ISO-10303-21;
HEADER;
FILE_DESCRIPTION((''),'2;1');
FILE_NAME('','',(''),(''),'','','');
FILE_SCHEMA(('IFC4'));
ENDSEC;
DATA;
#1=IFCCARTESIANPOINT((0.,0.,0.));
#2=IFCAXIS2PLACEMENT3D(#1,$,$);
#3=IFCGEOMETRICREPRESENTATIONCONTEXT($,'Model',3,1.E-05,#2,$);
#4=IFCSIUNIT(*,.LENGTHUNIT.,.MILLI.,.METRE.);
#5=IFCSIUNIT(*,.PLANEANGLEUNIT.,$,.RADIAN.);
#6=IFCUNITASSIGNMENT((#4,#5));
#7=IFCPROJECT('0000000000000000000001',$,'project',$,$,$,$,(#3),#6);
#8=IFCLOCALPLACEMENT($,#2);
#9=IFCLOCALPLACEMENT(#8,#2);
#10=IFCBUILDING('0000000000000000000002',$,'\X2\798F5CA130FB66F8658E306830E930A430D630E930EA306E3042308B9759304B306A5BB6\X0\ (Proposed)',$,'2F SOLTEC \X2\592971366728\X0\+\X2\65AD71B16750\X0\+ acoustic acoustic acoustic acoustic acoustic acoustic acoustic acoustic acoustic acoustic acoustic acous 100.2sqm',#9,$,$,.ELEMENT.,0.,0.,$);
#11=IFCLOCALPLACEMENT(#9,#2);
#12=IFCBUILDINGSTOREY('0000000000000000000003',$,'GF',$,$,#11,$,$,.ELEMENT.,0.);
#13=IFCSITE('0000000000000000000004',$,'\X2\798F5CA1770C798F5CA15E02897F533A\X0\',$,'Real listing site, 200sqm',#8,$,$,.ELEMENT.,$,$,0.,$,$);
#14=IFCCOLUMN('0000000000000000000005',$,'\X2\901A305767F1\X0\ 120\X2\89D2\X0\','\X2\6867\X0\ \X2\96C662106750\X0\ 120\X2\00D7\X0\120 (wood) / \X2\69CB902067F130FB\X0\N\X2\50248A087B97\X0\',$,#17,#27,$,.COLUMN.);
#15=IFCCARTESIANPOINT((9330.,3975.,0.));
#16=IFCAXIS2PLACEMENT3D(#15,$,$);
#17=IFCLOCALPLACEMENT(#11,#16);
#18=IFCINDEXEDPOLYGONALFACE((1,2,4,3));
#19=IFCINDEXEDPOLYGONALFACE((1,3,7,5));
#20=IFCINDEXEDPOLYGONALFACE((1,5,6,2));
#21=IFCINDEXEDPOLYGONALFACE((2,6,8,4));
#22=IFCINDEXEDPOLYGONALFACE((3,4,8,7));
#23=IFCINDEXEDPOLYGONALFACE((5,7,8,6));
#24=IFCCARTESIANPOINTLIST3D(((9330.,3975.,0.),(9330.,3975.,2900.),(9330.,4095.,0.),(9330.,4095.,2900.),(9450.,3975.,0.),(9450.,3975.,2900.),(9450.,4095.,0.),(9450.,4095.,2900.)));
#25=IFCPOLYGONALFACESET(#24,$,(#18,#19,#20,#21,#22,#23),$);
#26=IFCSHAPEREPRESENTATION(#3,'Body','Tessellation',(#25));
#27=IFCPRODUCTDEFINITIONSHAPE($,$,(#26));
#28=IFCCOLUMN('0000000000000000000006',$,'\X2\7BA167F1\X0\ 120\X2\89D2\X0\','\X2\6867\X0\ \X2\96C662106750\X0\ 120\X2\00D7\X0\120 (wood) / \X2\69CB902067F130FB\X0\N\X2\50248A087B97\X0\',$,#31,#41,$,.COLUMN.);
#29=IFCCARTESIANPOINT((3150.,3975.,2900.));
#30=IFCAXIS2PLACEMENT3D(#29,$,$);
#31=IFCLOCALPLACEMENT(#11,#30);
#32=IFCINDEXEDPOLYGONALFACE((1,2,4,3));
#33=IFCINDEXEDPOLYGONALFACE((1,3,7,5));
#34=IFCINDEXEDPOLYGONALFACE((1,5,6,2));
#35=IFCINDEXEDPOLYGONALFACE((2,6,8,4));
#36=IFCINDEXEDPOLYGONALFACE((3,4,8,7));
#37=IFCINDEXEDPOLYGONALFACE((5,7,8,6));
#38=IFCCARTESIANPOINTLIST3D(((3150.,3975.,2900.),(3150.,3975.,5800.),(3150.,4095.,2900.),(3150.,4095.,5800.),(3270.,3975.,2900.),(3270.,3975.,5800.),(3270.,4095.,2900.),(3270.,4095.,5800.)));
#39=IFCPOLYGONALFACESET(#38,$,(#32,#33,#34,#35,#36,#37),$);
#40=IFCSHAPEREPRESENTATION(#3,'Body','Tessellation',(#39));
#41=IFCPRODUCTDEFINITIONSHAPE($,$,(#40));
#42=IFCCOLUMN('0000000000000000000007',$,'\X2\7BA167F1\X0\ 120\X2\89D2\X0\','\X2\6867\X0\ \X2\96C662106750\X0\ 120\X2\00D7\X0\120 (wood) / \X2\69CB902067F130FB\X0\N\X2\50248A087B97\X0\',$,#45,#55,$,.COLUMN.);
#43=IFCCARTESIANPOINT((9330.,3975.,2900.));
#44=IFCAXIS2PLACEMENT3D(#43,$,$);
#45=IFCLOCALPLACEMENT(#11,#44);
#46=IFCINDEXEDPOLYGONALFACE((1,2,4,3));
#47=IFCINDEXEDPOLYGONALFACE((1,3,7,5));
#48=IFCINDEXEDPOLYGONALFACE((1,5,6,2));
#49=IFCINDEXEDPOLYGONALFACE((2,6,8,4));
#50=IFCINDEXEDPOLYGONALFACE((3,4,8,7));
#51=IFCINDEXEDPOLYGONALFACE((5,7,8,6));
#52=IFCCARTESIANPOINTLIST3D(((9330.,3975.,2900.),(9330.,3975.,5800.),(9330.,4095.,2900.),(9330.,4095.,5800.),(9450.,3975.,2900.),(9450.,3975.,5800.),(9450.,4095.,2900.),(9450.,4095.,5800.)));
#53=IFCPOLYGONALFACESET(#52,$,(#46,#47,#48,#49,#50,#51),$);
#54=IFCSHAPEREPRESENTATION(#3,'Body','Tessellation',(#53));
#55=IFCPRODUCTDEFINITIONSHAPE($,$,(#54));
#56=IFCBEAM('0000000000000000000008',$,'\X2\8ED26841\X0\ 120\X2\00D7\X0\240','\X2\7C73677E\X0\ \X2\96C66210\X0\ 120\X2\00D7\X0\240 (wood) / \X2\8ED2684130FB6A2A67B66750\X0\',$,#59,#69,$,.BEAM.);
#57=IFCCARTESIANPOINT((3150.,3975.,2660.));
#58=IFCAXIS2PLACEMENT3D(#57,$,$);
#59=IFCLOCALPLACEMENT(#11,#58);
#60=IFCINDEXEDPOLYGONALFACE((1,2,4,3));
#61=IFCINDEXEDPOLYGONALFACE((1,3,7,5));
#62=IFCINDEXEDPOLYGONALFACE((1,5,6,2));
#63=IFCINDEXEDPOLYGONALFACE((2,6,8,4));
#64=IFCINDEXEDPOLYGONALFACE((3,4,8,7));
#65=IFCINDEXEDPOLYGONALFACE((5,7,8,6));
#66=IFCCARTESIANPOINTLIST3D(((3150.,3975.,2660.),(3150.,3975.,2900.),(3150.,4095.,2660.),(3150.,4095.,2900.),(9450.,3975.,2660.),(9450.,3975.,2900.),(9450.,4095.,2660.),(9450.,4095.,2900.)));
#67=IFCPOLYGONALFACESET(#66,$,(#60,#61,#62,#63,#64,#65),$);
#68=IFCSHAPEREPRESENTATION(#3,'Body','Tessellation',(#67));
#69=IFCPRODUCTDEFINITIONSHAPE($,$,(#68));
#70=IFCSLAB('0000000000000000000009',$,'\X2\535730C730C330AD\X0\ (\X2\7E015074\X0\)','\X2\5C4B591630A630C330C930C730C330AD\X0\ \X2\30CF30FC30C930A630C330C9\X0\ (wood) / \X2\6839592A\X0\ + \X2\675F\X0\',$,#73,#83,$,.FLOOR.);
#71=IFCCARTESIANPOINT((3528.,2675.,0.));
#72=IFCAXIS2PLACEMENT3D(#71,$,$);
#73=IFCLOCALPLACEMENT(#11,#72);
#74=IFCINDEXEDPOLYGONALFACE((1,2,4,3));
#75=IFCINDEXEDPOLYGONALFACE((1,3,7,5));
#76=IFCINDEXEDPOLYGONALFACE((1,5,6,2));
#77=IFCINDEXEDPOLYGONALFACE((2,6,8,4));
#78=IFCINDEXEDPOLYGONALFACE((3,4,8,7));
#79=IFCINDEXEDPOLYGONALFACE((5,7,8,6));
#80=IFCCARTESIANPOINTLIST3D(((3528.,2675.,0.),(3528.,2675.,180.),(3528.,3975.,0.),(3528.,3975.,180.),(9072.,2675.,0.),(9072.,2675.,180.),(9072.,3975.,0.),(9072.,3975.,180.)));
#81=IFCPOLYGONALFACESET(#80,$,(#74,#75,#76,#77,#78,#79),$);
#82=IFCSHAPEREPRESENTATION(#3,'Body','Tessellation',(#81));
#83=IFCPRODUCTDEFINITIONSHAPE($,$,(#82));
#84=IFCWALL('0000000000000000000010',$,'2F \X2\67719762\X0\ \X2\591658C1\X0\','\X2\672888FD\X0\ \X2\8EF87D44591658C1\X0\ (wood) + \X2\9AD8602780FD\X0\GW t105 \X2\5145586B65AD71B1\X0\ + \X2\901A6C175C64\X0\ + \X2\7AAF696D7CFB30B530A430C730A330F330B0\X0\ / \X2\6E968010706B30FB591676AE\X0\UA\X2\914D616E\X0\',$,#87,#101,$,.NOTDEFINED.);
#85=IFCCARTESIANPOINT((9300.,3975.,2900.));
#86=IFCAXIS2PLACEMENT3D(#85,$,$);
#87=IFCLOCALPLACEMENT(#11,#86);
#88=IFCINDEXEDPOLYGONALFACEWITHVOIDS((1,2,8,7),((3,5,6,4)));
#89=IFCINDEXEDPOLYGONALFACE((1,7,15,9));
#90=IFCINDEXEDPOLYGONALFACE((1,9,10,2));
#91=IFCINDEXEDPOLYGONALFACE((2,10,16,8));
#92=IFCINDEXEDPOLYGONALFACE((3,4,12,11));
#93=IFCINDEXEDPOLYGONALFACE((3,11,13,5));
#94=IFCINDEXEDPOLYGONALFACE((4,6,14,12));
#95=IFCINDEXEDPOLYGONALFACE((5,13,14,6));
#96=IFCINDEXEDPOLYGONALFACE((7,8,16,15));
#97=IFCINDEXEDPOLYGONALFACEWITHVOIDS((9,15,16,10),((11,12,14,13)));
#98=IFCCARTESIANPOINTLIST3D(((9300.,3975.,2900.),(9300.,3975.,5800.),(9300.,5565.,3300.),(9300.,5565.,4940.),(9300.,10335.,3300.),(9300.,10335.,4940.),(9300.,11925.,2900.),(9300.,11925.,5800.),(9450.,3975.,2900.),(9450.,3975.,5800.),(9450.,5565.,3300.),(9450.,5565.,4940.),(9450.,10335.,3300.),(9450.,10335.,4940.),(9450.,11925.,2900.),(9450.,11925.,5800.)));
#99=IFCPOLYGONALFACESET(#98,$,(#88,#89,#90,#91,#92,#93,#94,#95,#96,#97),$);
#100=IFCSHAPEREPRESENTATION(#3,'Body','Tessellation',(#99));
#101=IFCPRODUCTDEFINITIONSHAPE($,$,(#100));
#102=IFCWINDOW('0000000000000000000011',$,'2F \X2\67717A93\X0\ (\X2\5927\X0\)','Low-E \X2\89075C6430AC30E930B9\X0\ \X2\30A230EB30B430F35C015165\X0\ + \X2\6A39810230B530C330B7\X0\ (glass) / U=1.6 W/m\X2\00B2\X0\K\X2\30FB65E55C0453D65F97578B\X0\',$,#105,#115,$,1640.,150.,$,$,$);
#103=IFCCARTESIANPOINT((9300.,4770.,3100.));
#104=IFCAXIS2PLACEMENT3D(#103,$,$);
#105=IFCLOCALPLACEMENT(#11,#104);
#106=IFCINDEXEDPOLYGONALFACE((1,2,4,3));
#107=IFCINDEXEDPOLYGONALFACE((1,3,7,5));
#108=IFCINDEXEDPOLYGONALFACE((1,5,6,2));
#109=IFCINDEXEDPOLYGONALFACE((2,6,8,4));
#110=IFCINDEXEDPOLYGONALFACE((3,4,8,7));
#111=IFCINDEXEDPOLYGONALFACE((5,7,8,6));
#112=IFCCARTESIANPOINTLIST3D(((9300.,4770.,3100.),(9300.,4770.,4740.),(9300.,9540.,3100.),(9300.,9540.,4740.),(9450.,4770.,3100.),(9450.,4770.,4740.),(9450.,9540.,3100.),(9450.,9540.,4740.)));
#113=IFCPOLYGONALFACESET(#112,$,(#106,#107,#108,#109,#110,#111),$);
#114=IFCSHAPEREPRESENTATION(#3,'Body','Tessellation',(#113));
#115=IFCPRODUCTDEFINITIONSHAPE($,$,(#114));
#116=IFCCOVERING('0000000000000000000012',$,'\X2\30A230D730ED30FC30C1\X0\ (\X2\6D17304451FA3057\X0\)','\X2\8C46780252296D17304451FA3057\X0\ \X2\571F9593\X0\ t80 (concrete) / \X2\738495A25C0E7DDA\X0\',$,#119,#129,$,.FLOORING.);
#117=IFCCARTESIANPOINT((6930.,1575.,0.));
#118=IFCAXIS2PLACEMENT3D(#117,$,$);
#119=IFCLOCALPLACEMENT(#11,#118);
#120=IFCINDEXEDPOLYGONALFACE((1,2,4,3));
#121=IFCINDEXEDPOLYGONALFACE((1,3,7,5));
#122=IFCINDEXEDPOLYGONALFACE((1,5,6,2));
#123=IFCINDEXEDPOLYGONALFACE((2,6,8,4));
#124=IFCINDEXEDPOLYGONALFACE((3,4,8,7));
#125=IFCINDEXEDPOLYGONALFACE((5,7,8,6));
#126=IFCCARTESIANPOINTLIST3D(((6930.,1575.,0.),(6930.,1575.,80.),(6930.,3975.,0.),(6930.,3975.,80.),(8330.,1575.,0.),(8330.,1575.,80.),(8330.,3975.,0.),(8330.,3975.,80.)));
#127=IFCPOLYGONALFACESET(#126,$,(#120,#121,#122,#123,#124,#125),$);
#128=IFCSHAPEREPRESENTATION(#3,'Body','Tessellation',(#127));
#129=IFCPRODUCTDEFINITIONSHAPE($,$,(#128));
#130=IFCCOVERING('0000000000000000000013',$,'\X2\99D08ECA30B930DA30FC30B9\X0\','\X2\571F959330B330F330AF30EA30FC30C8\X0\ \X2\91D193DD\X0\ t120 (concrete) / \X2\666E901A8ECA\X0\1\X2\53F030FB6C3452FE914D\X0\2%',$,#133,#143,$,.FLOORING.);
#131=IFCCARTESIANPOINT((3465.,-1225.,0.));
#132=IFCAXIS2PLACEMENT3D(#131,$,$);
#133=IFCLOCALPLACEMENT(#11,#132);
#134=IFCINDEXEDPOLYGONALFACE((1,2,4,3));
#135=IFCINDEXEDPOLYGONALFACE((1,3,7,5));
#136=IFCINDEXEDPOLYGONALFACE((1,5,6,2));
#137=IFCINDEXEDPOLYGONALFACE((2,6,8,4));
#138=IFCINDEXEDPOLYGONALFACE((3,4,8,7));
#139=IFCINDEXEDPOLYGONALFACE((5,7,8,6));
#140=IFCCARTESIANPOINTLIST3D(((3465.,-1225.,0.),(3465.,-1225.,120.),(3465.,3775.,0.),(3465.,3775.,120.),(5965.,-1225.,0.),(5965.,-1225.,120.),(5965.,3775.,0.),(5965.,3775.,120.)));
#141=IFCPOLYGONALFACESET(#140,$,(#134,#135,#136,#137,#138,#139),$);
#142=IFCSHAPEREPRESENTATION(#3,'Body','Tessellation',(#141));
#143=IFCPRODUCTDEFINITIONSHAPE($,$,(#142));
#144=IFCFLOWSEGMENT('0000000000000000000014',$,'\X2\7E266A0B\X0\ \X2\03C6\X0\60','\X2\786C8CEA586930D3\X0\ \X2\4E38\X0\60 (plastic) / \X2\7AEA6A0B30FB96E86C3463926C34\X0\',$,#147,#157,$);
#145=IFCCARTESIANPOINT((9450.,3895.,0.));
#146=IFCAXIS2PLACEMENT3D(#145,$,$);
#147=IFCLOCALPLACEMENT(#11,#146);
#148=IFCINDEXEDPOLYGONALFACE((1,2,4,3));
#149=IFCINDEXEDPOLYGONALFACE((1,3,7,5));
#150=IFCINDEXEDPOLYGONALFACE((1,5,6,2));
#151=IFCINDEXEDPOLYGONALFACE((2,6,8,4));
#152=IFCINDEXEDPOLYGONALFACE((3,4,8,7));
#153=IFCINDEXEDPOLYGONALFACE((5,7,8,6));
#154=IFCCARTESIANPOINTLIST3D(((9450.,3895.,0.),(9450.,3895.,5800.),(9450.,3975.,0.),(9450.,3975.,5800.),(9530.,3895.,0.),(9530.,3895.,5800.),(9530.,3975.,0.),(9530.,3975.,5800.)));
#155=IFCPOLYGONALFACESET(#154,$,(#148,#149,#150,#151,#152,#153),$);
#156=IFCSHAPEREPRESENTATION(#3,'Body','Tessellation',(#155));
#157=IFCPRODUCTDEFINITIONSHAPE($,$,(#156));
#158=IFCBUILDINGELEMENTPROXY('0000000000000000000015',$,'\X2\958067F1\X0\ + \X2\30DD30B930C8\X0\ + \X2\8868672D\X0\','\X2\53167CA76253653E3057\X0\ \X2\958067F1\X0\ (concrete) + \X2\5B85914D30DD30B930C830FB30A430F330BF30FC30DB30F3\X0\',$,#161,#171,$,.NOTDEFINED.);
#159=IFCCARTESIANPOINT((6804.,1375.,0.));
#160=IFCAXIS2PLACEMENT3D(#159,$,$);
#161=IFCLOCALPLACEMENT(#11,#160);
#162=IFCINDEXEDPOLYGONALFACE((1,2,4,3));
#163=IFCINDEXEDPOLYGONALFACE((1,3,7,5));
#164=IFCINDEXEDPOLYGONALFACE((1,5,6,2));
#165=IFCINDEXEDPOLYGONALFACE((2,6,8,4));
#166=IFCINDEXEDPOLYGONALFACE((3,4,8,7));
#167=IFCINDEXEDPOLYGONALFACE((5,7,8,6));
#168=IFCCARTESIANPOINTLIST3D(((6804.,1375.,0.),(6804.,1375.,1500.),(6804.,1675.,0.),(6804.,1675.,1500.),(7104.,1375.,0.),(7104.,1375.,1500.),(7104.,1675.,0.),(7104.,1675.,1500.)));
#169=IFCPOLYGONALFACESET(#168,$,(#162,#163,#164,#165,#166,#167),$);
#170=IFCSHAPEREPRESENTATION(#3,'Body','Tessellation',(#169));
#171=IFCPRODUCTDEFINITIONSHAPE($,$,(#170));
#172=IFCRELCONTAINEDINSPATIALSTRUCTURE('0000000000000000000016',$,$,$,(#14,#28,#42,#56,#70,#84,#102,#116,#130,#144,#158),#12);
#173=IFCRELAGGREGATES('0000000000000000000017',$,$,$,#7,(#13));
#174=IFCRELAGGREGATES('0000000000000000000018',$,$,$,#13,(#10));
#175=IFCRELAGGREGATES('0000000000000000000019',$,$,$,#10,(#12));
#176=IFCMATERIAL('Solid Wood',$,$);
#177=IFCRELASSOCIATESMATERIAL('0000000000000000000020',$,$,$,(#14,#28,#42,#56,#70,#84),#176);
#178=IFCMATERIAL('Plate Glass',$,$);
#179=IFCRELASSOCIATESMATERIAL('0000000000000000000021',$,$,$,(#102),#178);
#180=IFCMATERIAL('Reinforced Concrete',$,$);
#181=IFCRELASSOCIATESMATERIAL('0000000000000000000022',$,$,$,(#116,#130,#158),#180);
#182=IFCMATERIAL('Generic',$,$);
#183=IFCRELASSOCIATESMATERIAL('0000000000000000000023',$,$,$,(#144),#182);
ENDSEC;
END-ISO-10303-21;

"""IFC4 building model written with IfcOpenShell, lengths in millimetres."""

from ifc_helpers import new_model, si_unit, frame, frame_2d, origin, place, context, project, spatial, rectangle, extrude, material, element, fill, save


model = new_model("IFC4")

# Units and contexts
model_context = context("Model", 3, precision=1e-05, world=origin())
ifc_project = project(units=[si_unit("LENGTHUNIT", "METRE", prefix="MILLI"), si_unit("PLANEANGLEUNIT", "RADIAN")], contexts=[model_context])

# Site, building, storey
site_placement = place(None, origin())
site = spatial("IfcSite", under=ifc_project, at=site_placement, Name="福岡県福岡市西区", ObjectType="Real listing site, 200sqm", CompositionType="ELEMENT", RefElevation=0.0)
building_placement = place(site_placement, origin())
building = spatial("IfcBuilding", under=site, at=building_placement, Name="福岡・書斎とライブラリのある静かな家 (Proposed)", ObjectType="2F SOLTEC 天然木+断熱材+ acoustic acoustic acoustic acoustic acoustic acoustic acoustic acoustic acoustic acoustic acoustic acous 100.2sqm", CompositionType="ELEMENT", ElevationOfRefHeight=0.0, ElevationOfTerrain=0.0)
storey_placement = place(building_placement, origin())
storey = spatial("IfcBuildingStorey", under=building, at=storey_placement, Name="GF", CompositionType="ELEMENT", Elevation=0.0)

# Columns
ifc_material_1 = material(Name="Solid Wood")
column_1_placement = place(storey_placement, frame((9330.0, 3975.0, 0.0)))
element("IfcColumn", 1, at=column_1_placement, inside=storey, material=ifc_material_1, Name="通し柱 120角", Description="桧 集成材 120×120 (wood) / 構造柱・N値計算", PredefinedType="COLUMN", context=model_context, shape_type="SweptSolid", body=[
    extrude(rectangle(XDim=120.0, YDim=120.0, at=frame_2d((60.0, 60.0))), frame((9330.0, 3975.0, 0.0)), (0.0, 0.0, 1.0), 2900.0),
])
column_2_placement = place(storey_placement, frame((3150.0, 3975.0, 2900.0)))
element("IfcColumn", 2, at=column_2_placement, inside=storey, material=ifc_material_1, Name="管柱 120角", Description="桧 集成材 120×120 (wood) / 構造柱・N値計算", PredefinedType="COLUMN", context=model_context, shape_type="SweptSolid", body=[
    extrude(rectangle(XDim=120.0, YDim=120.0, at=frame_2d((60.0, 60.0))), frame((3150.0, 3975.0, 2900.0)), (0.0, 0.0, 1.0), 2900.0),
])
column_3_placement = place(storey_placement, frame((9330.0, 3975.0, 2900.0)))
element("IfcColumn", 3, at=column_3_placement, inside=storey, material=ifc_material_1, Name="管柱 120角", Description="桧 集成材 120×120 (wood) / 構造柱・N値計算", PredefinedType="COLUMN", context=model_context, shape_type="SweptSolid", body=[
    extrude(rectangle(XDim=120.0, YDim=120.0, at=frame_2d((60.0, 60.0))), frame((9330.0, 3975.0, 2900.0)), (0.0, 0.0, 1.0), 2900.0),
])

# Beam
beam_1_placement = place(storey_placement, frame((3150.0, 3975.0, 2660.0)))
element("IfcBeam", 4, at=beam_1_placement, inside=storey, material=ifc_material_1, Name="軒桁 120×240", Description="米松 集成 120×240 (wood) / 軒桁・横架材", PredefinedType="BEAM", context=model_context, shape_type="SweptSolid", body=[
    extrude(rectangle(XDim=6300.0, YDim=120.0, at=frame_2d((3150.0, 60.0))), frame((3150.0, 3975.0, 2660.0)), (0.0, 0.0, 1.0), 240.0),
])

# Slab
slab_placement = place(storey_placement, frame((3528.0, 2675.0, 0.0)))
element("IfcSlab", 5, at=slab_placement, inside=storey, material=ifc_material_1, Name="南デッキ (縁側)", Description="屋外ウッドデッキ ハードウッド (wood) / 根太 + 束", PredefinedType="FLOOR", context=model_context, shape_type="SweptSolid", body=[
    extrude(rectangle(XDim=5544.0, YDim=1300.0, at=frame_2d((2772.0, 650.0))), frame((3528.0, 2675.0, 0.0)), (0.0, 0.0, 1.0), 180.0),
])

# Wall, opening, window
ifc_material_2 = material(Name="Plate Glass")
wall_1_placement = place(storey_placement, frame((9300.0, 3975.0, 2900.0)))
wall_1 = element("IfcWall", 6, at=wall_1_placement, inside=storey, material=ifc_material_1, Name="2F 東面 外壁", Description="木製 軸組外壁 (wood) + 高性能GW t105 充填断熱 + 通気層 + 窯業系サイディング / 準耐火・外皮UA配慮", PredefinedType="NOTDEFINED", context=model_context, shape_type="SweptSolid", body=[
    extrude(rectangle(XDim=150.0, YDim=7950.0, at=frame_2d((75.0, 3975.0))), frame((9300.0, 3975.0, 2900.0)), (0.0, 0.0, 1.0), 2900.0),
])
opening_1_placement = place(storey_placement, frame((9300.0, 4770.0, 3100.0)))
opening_1 = element("IfcOpeningElement", 7, at=opening_1_placement, cuts=wall_1, PredefinedType="NOTDEFINED", context=model_context, shape_type="SweptSolid", body=[
    extrude(rectangle(XDim=150.0, YDim=4770.0, at=frame_2d((75.0, 2385.0))), frame((9300.0, 4770.0, 3100.0)), (0.0, 0.0, 1.0), 1640.0),
])
window_1_placement = place(storey_placement, frame((9300.0, 4770.0, 3100.0)))
window_1 = element("IfcWindow", 8, at=window_1_placement, inside=storey, material=ifc_material_2, Name="2F 東窓 (大)", Description="Low-E 複層ガラス アルゴン封入 + 樹脂サッシ (glass) / U=1.6 W/m²K・日射取得型", OverallHeight=1640.0, OverallWidth=150.0, context=model_context, shape_type="SweptSolid", body=[
    extrude(rectangle(XDim=150.0, YDim=4770.0, at=frame_2d((75.0, 2385.0))), frame((9300.0, 4770.0, 3100.0)), (0.0, 0.0, 1.0), 1640.0),
])
fill(opening_1, window_1)

# Coverings
ifc_material_3 = material(Name="Reinforced Concrete")
covering_1_placement = place(storey_placement, frame((6930.0, 1575.0, 0.0)))
element("IfcCovering", 9, at=covering_1_placement, inside=storey, material=ifc_material_3, Name="アプローチ (洗い出し)", Description="豆砂利洗い出し 土間 t80 (concrete) / 玄関導線", PredefinedType="FLOORING", context=model_context, shape_type="SweptSolid", body=[
    extrude(rectangle(XDim=1400.0, YDim=2400.0, at=frame_2d((700.0, 1200.0))), frame((6930.0, 1575.0, 0.0)), (0.0, 0.0, 1.0), 80.0),
])
covering_2_placement = place(storey_placement, frame((3465.0, -1225.0, 0.0)))
element("IfcCovering", 10, at=covering_2_placement, inside=storey, material=ifc_material_3, Name="駐車スペース", Description="土間コンクリート 金鏝 t120 (concrete) / 普通車1台・水勾配2%", PredefinedType="FLOORING", context=model_context, shape_type="SweptSolid", body=[
    extrude(rectangle(XDim=2500.0, YDim=5000.0, at=frame_2d((1250.0, 2500.0))), frame((3465.0, -1225.0, 0.0)), (0.0, 0.0, 1.0), 120.0),
])

# Flow segment
ifc_material_4 = material(Name="Generic")
flow_segment_placement = place(storey_placement, frame((9450.0, 3895.0, 0.0)))
element("IfcFlowSegment", 11, at=flow_segment_placement, inside=storey, material=ifc_material_4, Name="縦樋 φ60", Description="硬質塩ビ 丸60 (plastic) / 竪樋・雨水排水", context=model_context, shape_type="SweptSolid", body=[
    extrude(rectangle(XDim=80.0, YDim=80.0, at=frame_2d((40.0, 40.0))), frame((9450.0, 3895.0, 0.0)), (0.0, 0.0, 1.0), 5800.0),
])

# Building element proxy
proxy_placement = place(storey_placement, frame((6804.0, 1375.0, 0.0)))
element("IfcBuildingElementProxy", 12, at=proxy_placement, inside=storey, material=ifc_material_3, Name="門柱 + ポスト + 表札", Description="化粧打放し 門柱 (concrete) + 宅配ポスト・インターホン", PredefinedType="NOTDEFINED", context=model_context, shape_type="SweptSolid", body=[
    extrude(rectangle(XDim=300.0, YDim=300.0, at=frame_2d((150.0, 150.0))), frame((6804.0, 1375.0, 0.0)), (0.0, 0.0, 1.0), 1500.0),
])

save(model, "model.ifc")
